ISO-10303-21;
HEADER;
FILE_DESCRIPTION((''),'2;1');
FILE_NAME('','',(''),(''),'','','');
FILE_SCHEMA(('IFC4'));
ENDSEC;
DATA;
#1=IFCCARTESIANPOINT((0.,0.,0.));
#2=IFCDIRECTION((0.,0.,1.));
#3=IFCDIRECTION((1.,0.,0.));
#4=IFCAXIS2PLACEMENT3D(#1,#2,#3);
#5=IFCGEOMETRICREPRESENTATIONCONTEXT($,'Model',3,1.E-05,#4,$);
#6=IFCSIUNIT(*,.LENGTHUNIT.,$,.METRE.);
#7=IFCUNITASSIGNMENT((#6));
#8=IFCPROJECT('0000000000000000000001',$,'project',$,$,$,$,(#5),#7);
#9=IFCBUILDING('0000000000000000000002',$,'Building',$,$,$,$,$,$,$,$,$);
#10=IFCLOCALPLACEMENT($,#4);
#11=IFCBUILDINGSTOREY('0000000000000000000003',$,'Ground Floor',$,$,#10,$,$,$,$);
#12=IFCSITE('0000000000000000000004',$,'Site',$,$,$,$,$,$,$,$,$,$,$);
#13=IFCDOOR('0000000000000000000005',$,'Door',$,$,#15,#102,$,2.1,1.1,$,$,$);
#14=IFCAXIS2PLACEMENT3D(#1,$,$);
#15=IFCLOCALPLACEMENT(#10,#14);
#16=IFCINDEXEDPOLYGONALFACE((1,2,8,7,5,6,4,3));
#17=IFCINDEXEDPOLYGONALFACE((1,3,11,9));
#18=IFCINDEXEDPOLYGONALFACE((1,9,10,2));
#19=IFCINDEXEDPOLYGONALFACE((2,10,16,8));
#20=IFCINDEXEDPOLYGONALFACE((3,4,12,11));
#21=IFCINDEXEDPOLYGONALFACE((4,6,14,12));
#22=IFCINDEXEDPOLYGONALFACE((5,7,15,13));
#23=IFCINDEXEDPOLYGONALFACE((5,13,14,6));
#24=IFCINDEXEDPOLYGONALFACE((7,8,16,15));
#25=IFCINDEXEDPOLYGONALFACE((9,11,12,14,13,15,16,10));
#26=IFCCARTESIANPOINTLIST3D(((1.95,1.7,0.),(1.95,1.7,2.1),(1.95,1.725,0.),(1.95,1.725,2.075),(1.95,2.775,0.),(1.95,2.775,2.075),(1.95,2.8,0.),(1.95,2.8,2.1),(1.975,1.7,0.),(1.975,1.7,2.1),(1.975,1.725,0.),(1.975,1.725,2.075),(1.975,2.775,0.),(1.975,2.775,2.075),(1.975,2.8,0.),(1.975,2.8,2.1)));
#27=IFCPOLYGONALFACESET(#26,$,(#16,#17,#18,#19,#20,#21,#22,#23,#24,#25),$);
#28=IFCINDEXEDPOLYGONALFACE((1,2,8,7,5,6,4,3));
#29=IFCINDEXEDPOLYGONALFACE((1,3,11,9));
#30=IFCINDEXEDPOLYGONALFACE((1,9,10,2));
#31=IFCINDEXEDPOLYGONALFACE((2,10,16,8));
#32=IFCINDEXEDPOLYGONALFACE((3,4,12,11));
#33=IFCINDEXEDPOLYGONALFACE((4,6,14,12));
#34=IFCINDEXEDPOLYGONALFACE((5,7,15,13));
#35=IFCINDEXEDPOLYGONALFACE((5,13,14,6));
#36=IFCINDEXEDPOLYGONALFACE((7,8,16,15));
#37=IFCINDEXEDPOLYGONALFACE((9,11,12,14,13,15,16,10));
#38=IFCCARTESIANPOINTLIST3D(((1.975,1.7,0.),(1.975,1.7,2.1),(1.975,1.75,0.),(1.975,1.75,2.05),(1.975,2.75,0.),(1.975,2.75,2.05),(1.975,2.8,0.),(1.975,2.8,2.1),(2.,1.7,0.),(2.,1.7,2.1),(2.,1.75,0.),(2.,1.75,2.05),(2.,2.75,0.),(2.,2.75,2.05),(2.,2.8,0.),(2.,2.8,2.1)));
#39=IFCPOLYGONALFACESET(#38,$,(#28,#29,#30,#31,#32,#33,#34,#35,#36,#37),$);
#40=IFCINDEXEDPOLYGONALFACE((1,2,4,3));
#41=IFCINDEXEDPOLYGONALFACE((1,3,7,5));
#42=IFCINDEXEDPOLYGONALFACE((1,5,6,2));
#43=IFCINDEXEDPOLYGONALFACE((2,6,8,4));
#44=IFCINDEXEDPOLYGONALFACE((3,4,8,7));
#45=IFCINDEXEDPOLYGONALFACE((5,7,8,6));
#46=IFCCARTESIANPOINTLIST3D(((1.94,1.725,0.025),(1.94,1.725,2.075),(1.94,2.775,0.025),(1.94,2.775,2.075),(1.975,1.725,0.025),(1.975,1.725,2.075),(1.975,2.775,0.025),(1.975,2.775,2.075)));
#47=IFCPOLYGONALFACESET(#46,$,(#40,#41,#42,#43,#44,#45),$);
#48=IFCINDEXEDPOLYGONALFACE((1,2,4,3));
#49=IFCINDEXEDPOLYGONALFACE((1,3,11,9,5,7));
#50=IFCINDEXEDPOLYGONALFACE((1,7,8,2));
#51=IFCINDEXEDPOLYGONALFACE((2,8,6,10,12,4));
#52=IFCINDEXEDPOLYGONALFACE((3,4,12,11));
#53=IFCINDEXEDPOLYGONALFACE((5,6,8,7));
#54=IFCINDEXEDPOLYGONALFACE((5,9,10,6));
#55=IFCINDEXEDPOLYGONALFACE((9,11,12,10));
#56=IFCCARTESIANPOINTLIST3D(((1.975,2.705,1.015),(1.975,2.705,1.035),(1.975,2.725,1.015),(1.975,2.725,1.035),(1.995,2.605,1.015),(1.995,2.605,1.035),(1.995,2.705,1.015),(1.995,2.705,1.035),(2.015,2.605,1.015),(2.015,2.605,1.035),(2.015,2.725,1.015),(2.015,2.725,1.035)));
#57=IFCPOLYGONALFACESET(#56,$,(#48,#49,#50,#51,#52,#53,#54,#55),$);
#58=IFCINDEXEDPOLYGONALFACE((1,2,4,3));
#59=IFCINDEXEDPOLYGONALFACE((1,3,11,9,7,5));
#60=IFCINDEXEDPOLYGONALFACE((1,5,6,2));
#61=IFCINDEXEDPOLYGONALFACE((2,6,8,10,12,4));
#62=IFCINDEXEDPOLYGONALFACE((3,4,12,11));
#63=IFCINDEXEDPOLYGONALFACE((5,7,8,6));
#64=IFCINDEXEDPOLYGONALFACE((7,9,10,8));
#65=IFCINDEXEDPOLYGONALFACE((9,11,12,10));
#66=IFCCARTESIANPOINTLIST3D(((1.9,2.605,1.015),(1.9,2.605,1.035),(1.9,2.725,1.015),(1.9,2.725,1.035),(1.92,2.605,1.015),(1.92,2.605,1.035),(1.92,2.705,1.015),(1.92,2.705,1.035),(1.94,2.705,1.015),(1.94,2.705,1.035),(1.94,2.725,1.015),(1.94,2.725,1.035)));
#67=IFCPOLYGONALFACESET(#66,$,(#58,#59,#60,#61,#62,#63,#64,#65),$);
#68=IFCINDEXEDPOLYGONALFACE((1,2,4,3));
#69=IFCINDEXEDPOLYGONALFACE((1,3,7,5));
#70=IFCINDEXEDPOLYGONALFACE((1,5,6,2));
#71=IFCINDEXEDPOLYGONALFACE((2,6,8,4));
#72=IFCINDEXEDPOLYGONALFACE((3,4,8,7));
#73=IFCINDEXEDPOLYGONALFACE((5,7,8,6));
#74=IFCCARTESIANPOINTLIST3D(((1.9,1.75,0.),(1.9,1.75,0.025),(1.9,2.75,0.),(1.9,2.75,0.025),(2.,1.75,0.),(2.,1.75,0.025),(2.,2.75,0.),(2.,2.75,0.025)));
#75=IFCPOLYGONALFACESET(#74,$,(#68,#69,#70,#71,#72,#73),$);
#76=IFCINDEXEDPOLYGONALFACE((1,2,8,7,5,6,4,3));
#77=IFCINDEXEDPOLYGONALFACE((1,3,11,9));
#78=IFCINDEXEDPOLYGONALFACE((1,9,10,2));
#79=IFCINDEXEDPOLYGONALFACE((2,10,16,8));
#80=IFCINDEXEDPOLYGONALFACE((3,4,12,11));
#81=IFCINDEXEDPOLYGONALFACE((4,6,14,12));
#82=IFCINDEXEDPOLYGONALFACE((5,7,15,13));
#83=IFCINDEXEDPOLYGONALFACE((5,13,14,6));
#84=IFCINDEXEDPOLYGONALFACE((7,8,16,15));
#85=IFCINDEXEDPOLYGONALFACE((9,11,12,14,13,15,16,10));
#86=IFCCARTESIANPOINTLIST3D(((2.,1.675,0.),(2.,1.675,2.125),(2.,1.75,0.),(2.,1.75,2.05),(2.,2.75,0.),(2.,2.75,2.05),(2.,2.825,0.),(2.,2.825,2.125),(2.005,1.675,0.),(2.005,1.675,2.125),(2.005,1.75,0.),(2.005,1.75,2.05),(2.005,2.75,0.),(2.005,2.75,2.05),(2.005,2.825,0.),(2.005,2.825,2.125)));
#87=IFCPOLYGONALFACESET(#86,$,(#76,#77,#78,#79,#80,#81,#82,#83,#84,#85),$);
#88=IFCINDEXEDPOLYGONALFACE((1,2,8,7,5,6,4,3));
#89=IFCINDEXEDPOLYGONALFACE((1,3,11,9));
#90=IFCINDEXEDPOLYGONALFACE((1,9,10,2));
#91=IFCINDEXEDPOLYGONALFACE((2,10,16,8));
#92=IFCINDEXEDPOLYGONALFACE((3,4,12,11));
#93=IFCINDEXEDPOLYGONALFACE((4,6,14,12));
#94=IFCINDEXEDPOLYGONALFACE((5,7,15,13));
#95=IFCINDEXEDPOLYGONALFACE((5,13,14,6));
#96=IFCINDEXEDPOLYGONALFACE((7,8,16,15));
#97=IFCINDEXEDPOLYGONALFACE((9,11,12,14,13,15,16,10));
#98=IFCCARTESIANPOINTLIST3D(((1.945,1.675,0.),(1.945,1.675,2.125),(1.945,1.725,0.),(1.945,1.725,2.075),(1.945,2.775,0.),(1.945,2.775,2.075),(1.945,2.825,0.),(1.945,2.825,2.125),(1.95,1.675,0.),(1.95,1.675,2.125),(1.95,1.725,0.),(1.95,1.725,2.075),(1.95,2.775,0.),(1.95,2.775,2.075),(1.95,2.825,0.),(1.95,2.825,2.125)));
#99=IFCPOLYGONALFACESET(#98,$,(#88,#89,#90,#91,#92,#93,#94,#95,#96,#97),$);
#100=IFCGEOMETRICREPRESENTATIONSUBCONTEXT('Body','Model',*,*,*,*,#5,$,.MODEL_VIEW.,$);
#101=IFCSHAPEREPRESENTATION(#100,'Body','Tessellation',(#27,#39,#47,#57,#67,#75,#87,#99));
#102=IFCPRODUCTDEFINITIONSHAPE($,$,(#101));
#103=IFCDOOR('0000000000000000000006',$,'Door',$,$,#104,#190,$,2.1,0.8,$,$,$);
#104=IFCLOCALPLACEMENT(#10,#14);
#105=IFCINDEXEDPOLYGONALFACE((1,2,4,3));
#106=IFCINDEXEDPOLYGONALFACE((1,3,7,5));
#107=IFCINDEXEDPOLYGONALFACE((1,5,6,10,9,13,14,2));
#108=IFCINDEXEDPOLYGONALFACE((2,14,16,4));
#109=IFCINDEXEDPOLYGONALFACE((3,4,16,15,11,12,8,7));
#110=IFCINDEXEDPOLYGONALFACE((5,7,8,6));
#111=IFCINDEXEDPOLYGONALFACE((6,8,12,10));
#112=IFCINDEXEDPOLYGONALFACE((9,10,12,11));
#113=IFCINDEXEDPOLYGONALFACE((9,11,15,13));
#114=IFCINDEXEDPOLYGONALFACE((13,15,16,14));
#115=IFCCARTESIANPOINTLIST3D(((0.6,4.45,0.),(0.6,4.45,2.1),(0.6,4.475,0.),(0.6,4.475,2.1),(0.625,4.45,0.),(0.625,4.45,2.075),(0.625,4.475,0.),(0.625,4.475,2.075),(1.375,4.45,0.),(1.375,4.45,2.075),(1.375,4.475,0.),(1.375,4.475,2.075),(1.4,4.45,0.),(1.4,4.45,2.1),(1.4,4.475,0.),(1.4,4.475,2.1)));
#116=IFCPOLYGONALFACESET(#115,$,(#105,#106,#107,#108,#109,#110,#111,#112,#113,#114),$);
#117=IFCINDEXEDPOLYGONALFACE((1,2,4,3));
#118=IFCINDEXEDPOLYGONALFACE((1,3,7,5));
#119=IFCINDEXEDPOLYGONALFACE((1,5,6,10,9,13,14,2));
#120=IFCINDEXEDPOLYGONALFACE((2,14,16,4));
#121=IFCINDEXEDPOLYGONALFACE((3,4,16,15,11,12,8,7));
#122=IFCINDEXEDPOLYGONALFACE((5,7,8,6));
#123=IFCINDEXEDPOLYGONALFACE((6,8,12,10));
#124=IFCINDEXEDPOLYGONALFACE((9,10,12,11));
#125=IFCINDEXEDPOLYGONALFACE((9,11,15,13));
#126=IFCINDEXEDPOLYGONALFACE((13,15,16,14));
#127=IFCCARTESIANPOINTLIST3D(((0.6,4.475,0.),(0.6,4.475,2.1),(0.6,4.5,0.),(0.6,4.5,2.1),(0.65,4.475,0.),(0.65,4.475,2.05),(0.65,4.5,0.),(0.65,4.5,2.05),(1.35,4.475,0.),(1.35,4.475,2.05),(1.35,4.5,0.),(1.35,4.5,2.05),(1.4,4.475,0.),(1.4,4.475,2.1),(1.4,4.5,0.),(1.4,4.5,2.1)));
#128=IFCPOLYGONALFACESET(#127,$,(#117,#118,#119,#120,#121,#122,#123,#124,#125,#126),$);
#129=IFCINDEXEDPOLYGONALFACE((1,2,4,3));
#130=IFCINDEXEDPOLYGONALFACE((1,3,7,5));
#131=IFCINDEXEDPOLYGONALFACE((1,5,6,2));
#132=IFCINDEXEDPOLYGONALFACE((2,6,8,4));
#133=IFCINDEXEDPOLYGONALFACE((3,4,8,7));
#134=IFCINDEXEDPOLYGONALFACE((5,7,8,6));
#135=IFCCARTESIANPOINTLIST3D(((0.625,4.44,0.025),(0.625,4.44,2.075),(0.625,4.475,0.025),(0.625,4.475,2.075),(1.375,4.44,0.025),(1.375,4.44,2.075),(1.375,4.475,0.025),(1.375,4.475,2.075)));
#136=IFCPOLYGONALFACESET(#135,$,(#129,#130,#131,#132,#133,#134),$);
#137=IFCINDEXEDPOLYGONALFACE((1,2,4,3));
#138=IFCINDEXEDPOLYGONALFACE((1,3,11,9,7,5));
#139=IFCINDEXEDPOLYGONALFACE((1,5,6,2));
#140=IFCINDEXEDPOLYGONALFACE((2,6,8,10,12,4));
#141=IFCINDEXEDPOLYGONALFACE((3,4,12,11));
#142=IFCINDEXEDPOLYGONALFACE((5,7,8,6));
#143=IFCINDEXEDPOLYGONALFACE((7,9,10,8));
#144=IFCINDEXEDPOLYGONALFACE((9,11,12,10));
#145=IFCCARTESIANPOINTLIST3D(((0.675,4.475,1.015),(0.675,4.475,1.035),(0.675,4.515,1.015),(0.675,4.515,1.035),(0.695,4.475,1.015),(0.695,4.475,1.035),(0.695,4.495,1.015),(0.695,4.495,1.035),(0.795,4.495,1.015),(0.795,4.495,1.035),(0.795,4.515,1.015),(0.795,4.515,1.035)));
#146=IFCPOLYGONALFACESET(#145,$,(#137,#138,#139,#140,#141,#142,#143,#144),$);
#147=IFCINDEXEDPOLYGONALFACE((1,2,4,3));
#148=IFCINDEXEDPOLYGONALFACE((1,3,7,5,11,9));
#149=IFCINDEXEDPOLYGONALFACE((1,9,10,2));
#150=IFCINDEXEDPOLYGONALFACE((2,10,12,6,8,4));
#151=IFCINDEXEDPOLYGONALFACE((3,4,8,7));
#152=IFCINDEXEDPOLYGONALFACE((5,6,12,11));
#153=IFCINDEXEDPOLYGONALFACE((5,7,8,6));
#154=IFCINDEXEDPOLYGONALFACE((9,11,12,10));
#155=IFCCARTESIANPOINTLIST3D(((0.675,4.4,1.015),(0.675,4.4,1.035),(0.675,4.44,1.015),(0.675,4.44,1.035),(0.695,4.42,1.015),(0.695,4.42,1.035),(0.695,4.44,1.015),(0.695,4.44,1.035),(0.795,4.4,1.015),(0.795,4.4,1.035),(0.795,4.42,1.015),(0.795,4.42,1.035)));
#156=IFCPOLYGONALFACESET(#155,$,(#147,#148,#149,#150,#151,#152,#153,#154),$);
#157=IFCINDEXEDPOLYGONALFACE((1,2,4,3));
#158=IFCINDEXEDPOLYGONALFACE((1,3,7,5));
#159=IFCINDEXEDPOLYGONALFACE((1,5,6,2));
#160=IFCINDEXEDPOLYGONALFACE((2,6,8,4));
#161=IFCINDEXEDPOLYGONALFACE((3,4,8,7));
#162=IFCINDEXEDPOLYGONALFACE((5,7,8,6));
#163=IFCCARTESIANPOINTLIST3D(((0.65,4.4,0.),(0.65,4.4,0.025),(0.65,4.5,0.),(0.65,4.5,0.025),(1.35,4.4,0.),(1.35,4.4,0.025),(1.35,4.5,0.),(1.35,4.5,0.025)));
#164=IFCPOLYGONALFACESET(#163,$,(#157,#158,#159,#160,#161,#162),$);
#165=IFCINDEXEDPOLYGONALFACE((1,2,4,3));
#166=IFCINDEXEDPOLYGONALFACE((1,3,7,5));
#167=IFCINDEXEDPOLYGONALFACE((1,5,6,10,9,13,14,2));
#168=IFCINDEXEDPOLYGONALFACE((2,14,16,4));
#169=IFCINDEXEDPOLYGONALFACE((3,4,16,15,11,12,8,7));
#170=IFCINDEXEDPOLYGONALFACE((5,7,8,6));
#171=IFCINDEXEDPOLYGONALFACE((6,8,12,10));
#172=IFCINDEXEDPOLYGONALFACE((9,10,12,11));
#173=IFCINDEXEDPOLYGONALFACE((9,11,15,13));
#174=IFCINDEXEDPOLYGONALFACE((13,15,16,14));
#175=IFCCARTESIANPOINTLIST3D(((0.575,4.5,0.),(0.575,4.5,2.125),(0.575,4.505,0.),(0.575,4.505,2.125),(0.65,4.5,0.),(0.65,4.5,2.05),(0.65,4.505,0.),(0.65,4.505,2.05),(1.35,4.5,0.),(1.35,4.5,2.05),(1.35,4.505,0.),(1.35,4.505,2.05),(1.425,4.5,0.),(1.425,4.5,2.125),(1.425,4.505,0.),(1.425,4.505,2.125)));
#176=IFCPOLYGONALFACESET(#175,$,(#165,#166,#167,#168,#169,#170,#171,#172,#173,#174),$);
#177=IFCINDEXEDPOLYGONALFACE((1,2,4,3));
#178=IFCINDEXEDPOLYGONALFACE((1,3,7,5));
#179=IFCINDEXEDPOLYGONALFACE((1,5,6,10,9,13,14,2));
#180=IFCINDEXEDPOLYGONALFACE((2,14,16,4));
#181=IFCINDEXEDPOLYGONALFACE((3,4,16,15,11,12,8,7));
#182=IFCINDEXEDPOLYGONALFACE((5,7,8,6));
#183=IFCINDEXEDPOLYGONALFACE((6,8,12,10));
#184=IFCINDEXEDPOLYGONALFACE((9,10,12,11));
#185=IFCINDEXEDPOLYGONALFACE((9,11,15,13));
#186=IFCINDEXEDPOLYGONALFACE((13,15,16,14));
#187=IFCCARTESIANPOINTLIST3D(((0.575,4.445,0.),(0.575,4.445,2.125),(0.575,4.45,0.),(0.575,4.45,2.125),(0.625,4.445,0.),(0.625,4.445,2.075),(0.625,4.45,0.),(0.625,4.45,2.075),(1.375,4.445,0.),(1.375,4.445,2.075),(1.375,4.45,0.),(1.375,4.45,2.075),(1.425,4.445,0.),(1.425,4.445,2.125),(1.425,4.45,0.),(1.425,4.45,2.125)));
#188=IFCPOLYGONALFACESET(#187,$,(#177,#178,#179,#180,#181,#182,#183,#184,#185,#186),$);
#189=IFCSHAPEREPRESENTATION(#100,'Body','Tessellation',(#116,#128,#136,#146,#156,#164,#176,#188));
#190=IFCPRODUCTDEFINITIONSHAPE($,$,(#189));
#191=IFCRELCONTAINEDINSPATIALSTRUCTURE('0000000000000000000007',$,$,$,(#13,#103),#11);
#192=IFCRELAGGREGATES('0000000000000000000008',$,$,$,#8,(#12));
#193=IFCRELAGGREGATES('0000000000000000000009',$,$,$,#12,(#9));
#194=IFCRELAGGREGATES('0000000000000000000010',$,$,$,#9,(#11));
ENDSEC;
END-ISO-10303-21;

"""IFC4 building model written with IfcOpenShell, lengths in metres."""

from ifc_helpers import new_model, si_unit, frame, origin_with_axes, place, context, subcontext, project, spatial, line, indexed_curve, outline, extrude, element, save


model = new_model("IFC4")

# Units and contexts
model_context = context("Model", 3, precision=1e-05, world=origin_with_axes())
body_context = subcontext(model_context, "Body", "Model", "MODEL_VIEW")
ifc_project = project(units=[si_unit("LENGTHUNIT", "METRE")], contexts=[model_context])

# Site, building, storey
site = spatial("IfcSite", under=ifc_project, Name="Site")
building = spatial("IfcBuilding", under=site, Name="Building")
storey_placement = place(None, origin_with_axes())
storey = spatial("IfcBuildingStorey", under=building, at=storey_placement, Name="Ground Floor")

# Doors
door_1_placement = place(storey_placement, frame((2.0, 1.7, 0.0), z_axis=(0.0, 0.0, 1.0), x_axis=(0.0, 1.0, 0.0)))
element("IfcDoor", 1, at=door_1_placement, inside=storey, Name="Door", OverallHeight=2.1, OverallWidth=1.1, context=body_context, shape_type="SweptSolid", body=[
    extrude(outline(indexed_curve([(0.0, 0.0), (0.0, 2.1), (1.1, 2.1), (1.1, 0.0), (1.075, 0.0), (1.075, 2.075), (0.025, 2.075), (0.025, 0.0)], segments=[line(1, 2, 3, 4, 5, 6, 7, 8, 1)])), frame((0.0, 0.025, 0.0), z_axis=(0.0, -1.0, 0.0), x_axis=(1.0, 0.0, 0.0)), (0.0, 0.0, -1.0), 0.025),
    extrude(outline(indexed_curve([(0.0, 0.0), (0.0, 2.1), (1.1, 2.1), (1.1, 0.0), (1.05, 0.0), (1.05, 2.05), (0.05, 2.05), (0.05, 0.0)], segments=[line(1, 2, 3, 4, 5, 6, 7, 8, 1)])), frame((0.0, 0.0, 0.0), z_axis=(0.0, -1.0, 0.0), x_axis=(1.0, 0.0, 0.0)), (0.0, 0.0, -1.0), 0.025),
    extrude(outline(indexed_curve([(0.0, 0.0), (1.05, 0.0), (1.05, 0.035), (0.0, 0.035)], segments=[line(1, 2, 3, 4, 1)])), frame((0.025, 0.025, 0.025), z_axis=(0.0, 0.0, 1.0), x_axis=(1.0, 0.0, 0.0)), (0.0, 0.0, 1.0), 2.05),
    extrude(outline(indexed_curve([(0.0, 0.0), (0.0, -0.04), (-0.12, -0.04), (-0.12, -0.02), (-0.02, -0.02), (-0.02, 0.0)], segments=[line(1, 2, 3, 4, 5, 6, 1)])), frame((1.025, 0.025, 1.015), z_axis=(0.0, 0.0, 1.0), x_axis=(1.0, 0.0, 0.0)), (0.0, 0.0, 1.0), 0.02),
    extrude(outline(indexed_curve([(0.0, 0.0), (0.0, 0.04), (-0.12, 0.04), (-0.12, 0.02), (-0.02, 0.02), (-0.02, 0.0)], segments=[line(1, 2, 3, 4, 5, 6, 1)])), frame((1.025, 0.06, 1.015), z_axis=(0.0, 0.0, 1.0), x_axis=(1.0, 0.0, 0.0)), (0.0, 0.0, 1.0), 0.02),
    extrude(outline(indexed_curve([(0.0, 0.0), (1.0, 0.0), (1.0, 0.1), (0.0, 0.1)], segments=[line(1, 2, 3, 4, 1)])), frame((0.05, 0.0, 0.0), z_axis=(0.0, 0.0, 1.0), x_axis=(1.0, 0.0, 0.0)), (0.0, 0.0, 1.0), 0.025),
    extrude(outline(indexed_curve([(0.0, 0.0), (0.0, 2.125), (1.15, 2.125), (1.15, 0.0), (1.075, 0.0), (1.075, 2.05), (0.075, 2.05), (0.075, 0.0)], segments=[line(1, 2, 3, 4, 5, 6, 7, 8, 1)])), frame((-0.025, -0.005, 0.0), z_axis=(0.0, -1.0, 0.0), x_axis=(1.0, 0.0, 0.0)), (0.0, 0.0, -1.0), 0.005),
    extrude(outline(indexed_curve([(0.0, 0.0), (0.0, 2.125), (1.15, 2.125), (1.15, 0.0), (1.1, 0.0), (1.1, 2.075), (0.05, 2.075), (0.05, 0.0)], segments=[line(1, 2, 3, 4, 5, 6, 7, 8, 1)])), frame((-0.025, 0.05, 0.0), z_axis=(0.0, -1.0, 0.0), x_axis=(1.0, 0.0, 0.0)), (0.0, 0.0, -1.0), 0.005),
])
door_2_placement = place(storey_placement, frame((1.4, 4.5, 0.0), z_axis=(0.0, 0.0, 1.0), x_axis=(-1.0, 0.0, 0.0)))
element("IfcDoor", 2, at=door_2_placement, inside=storey, Name="Door", OverallHeight=2.1, OverallWidth=0.8, context=body_context, shape_type="SweptSolid", body=[
    extrude(outline(indexed_curve([(0.0, 0.0), (0.0, 2.1), (0.8, 2.1), (0.8, 0.0), (0.775, 0.0), (0.775, 2.075), (0.025, 2.075), (0.025, 0.0)], segments=[line(1, 2, 3, 4, 5, 6, 7, 8, 1)])), frame((0.0, 0.025, 0.0), z_axis=(0.0, -1.0, 0.0), x_axis=(1.0, 0.0, 0.0)), (0.0, 0.0, -1.0), 0.025),
    extrude(outline(indexed_curve([(0.0, 0.0), (0.0, 2.1), (0.8, 2.1), (0.8, 0.0), (0.75, 0.0), (0.75, 2.05), (0.05, 2.05), (0.05, 0.0)], segments=[line(1, 2, 3, 4, 5, 6, 7, 8, 1)])), frame((0.0, 0.0, 0.0), z_axis=(0.0, -1.0, 0.0), x_axis=(1.0, 0.0, 0.0)), (0.0, 0.0, -1.0), 0.025),
    extrude(outline(indexed_curve([(0.0, 0.0), (0.75, 0.0), (0.75, 0.035), (0.0, 0.035)], segments=[line(1, 2, 3, 4, 1)])), frame((0.025, 0.025, 0.025), z_axis=(0.0, 0.0, 1.0), x_axis=(1.0, 0.0, 0.0)), (0.0, 0.0, 1.0), 2.05),
    extrude(outline(indexed_curve([(0.0, 0.0), (0.0, -0.04), (-0.12, -0.04), (-0.12, -0.02), (-0.02, -0.02), (-0.02, 0.0)], segments=[line(1, 2, 3, 4, 5, 6, 1)])), frame((0.725, 0.025, 1.015), z_axis=(0.0, 0.0, 1.0), x_axis=(1.0, 0.0, 0.0)), (0.0, 0.0, 1.0), 0.02),
    extrude(outline(indexed_curve([(0.0, 0.0), (0.0, 0.04), (-0.12, 0.04), (-0.12, 0.02), (-0.02, 0.02), (-0.02, 0.0)], segments=[line(1, 2, 3, 4, 5, 6, 1)])), frame((0.725, 0.06, 1.015), z_axis=(0.0, 0.0, 1.0), x_axis=(1.0, 0.0, 0.0)), (0.0, 0.0, 1.0), 0.02),
    extrude(outline(indexed_curve([(0.0, 0.0), (0.7, 0.0), (0.7, 0.1), (0.0, 0.1)], segments=[line(1, 2, 3, 4, 1)])), frame((0.05, 0.0, 0.0), z_axis=(0.0, 0.0, 1.0), x_axis=(1.0, 0.0, 0.0)), (0.0, 0.0, 1.0), 0.025),
    extrude(outline(indexed_curve([(0.0, 0.0), (0.0, 2.125), (0.85, 2.125), (0.85, 0.0), (0.775, 0.0), (0.775, 2.05), (0.075, 2.05), (0.075, 0.0)], segments=[line(1, 2, 3, 4, 5, 6, 7, 8, 1)])), frame((-0.025, -0.005, 0.0), z_axis=(0.0, -1.0, 0.0), x_axis=(1.0, 0.0, 0.0)), (0.0, 0.0, -1.0), 0.005),
    extrude(outline(indexed_curve([(0.0, 0.0), (0.0, 2.125), (0.85, 2.125), (0.85, 0.0), (0.8, 0.0), (0.8, 2.075), (0.05, 2.075), (0.05, 0.0)], segments=[line(1, 2, 3, 4, 5, 6, 7, 8, 1)])), frame((-0.025, 0.05, 0.0), z_axis=(0.0, -1.0, 0.0), x_axis=(1.0, 0.0, 0.0)), (0.0, 0.0, -1.0), 0.005),
])

save(model, "model.ifc")
